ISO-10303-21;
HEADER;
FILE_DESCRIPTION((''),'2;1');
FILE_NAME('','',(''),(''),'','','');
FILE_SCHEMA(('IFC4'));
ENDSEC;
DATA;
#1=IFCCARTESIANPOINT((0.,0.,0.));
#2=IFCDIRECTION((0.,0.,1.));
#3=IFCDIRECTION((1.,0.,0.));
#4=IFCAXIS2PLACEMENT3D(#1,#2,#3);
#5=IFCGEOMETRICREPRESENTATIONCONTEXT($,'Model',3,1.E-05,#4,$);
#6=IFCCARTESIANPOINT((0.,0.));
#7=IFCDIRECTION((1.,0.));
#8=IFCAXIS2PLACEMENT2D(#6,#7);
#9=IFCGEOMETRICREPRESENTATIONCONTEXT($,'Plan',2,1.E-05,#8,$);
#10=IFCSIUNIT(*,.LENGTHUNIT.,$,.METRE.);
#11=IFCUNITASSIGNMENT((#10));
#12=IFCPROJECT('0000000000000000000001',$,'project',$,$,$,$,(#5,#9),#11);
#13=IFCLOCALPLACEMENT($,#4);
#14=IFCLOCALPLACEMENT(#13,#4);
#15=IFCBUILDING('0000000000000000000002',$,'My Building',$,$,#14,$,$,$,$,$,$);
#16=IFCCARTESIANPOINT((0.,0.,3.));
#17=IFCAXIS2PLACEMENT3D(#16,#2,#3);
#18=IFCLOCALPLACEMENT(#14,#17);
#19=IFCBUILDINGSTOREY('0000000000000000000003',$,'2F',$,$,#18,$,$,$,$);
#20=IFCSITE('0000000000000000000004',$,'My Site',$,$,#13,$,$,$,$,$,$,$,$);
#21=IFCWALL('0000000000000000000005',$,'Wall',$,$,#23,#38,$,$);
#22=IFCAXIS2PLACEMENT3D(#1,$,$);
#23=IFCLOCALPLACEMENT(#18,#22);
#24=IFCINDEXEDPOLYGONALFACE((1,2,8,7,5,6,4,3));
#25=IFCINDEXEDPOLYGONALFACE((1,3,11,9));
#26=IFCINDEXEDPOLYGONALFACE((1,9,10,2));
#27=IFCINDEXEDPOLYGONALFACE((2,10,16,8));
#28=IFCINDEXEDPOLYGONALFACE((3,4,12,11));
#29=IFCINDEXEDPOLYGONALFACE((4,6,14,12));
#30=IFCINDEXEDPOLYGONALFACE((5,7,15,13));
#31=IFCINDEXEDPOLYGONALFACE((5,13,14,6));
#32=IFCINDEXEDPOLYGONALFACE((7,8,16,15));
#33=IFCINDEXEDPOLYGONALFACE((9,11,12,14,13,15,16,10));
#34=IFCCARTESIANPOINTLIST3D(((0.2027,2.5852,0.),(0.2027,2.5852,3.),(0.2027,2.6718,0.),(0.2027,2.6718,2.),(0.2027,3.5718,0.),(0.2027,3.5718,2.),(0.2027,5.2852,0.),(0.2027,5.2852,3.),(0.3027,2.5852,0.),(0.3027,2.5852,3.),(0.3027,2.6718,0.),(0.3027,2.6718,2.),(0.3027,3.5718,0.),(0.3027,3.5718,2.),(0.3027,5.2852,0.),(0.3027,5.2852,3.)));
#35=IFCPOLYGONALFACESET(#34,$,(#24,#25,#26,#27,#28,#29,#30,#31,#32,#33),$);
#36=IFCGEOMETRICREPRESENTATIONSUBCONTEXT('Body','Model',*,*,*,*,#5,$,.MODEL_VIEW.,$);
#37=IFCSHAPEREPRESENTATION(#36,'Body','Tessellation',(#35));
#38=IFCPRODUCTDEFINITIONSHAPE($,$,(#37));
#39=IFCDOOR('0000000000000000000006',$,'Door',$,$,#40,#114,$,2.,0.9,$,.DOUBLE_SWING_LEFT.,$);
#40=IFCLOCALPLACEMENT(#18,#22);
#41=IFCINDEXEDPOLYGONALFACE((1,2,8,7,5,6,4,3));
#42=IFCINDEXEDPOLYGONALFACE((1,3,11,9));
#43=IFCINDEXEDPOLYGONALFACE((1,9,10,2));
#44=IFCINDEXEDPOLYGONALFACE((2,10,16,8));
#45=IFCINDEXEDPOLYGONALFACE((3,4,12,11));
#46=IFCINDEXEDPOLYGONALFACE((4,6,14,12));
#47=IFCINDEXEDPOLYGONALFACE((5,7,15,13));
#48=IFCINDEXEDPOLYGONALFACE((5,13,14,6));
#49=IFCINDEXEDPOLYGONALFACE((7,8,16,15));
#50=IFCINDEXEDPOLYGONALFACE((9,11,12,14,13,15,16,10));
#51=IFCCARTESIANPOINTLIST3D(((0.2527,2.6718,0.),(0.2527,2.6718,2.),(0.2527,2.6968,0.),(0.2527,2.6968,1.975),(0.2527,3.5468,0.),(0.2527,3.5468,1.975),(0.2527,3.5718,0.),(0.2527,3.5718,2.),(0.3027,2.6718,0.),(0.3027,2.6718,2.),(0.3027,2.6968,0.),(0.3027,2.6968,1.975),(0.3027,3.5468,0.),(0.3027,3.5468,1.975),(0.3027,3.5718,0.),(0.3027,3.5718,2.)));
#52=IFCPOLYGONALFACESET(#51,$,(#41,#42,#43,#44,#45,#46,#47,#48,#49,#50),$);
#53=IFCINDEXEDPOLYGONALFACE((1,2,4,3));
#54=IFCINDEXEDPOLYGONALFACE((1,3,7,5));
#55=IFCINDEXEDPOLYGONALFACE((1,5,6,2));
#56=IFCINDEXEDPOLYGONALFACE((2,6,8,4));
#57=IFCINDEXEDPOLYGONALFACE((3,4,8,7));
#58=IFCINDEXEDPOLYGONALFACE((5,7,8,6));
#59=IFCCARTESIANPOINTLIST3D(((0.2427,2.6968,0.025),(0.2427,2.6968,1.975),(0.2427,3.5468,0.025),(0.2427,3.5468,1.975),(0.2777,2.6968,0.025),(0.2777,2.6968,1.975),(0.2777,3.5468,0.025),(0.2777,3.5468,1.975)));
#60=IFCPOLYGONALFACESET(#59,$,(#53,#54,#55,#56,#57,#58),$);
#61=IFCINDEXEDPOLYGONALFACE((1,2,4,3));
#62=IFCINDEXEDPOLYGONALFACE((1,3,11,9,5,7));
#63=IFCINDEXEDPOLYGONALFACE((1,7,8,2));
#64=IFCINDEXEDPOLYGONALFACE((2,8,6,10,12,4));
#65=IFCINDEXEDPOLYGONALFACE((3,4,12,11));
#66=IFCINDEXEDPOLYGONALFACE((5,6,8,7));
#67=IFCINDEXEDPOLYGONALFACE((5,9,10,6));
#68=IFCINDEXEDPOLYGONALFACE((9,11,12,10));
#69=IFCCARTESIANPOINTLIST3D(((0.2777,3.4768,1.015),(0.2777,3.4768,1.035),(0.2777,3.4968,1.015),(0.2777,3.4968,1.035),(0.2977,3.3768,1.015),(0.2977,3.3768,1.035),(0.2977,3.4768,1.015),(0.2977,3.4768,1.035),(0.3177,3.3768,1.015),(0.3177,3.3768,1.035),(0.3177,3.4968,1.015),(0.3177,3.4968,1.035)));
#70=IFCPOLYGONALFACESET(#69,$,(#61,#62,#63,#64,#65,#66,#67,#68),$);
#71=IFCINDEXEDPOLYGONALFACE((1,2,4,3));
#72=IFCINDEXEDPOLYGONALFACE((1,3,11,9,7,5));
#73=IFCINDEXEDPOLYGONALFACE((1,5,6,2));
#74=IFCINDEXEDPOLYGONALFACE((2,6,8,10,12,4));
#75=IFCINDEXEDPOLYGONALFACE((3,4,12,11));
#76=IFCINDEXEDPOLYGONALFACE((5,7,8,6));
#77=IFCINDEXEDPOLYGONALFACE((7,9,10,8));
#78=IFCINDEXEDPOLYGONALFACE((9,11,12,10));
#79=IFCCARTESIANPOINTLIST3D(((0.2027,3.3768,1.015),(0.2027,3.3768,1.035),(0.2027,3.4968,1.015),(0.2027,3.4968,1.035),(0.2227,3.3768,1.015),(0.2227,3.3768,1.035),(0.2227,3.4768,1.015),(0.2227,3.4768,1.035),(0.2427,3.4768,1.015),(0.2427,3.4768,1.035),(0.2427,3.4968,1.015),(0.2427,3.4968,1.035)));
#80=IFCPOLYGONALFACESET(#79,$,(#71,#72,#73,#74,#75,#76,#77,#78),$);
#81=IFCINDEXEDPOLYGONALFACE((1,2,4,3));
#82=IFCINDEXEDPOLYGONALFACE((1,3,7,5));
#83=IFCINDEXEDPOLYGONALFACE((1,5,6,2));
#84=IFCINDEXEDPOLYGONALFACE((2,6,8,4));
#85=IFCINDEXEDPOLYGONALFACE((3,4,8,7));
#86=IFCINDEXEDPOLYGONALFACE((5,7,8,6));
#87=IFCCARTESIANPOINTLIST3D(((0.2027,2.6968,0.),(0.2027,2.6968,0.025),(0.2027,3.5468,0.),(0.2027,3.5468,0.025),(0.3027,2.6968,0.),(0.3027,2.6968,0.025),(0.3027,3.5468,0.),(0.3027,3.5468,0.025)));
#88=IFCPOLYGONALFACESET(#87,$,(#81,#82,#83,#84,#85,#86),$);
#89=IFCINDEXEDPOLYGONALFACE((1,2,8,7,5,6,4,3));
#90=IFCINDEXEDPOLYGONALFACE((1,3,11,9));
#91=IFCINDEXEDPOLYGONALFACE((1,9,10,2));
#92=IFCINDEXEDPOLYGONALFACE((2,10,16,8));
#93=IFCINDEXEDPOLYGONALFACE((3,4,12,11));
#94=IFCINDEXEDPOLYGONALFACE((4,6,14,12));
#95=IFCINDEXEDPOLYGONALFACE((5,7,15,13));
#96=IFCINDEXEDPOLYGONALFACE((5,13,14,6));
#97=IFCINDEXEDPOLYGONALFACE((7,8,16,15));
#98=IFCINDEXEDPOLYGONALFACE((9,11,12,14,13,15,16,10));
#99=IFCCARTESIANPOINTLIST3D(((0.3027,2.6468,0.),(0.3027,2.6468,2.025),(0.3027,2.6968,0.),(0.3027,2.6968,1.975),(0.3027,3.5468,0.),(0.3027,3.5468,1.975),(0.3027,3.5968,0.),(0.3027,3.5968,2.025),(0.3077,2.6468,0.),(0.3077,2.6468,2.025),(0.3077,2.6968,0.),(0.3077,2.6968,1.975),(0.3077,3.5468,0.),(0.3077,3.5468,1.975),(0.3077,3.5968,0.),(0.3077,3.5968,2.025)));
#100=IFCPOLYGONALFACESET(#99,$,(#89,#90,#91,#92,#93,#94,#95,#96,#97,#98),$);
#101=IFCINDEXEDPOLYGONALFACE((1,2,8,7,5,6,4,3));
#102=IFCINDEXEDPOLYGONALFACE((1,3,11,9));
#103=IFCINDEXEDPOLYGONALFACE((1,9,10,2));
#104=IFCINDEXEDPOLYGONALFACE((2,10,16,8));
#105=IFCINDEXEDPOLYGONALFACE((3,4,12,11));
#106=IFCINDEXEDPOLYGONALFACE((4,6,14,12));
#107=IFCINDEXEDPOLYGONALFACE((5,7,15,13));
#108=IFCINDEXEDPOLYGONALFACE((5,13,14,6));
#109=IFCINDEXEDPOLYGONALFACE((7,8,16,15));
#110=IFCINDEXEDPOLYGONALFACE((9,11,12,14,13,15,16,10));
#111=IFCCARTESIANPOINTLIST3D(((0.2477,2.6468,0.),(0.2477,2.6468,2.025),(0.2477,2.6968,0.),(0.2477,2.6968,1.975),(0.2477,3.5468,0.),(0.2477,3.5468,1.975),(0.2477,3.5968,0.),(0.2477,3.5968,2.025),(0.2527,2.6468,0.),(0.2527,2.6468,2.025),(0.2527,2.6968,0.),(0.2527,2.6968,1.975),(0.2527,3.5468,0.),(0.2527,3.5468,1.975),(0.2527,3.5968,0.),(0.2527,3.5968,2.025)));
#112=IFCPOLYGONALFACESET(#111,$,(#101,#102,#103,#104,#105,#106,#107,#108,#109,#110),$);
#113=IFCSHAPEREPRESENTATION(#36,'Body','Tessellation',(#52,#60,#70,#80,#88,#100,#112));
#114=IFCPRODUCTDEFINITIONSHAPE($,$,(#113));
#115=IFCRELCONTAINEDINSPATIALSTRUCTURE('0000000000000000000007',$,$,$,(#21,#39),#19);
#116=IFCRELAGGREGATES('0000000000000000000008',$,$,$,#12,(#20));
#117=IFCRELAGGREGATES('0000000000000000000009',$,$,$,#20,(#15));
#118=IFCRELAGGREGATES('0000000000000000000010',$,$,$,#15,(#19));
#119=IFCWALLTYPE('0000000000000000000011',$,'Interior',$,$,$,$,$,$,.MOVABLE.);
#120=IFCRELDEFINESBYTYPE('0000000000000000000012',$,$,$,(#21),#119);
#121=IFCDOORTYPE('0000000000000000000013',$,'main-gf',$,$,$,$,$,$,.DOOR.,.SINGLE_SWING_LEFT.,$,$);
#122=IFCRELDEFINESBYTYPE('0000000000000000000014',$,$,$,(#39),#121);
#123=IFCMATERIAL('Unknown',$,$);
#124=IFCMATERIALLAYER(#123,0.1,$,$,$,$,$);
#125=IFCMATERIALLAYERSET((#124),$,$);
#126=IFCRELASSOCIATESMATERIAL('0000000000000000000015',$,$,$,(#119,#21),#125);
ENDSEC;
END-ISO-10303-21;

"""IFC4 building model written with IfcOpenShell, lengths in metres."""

from ifc_helpers import new_model, entity, si_unit, frame, origin_with_axes, origin_2d_with_axis, place, context, subcontext, project, spatial, line, indexed_curve, outline, extrude, shape, source, transform, mapped, material, layer, layer_set, layer_usage, type_object, type_shapes, element, fill, save


model = new_model("IFC4")

# Units and contexts
model_context = context("Model", 3, precision=1e-05, world=origin_with_axes())
plan_context = context("Plan", 2, precision=1e-05, world=origin_2d_with_axis())
body_context_1 = subcontext(model_context, "Body", "Model", "MODEL_VIEW")
body_context_2 = subcontext(plan_context, "Body", "Plan", "PLAN_VIEW")
ifc_project = project(units=[si_unit("LENGTHUNIT", "METRE")], contexts=[model_context, plan_context])

# Site, building, storey
site_placement = place(None, origin_with_axes())
site = spatial("IfcSite", under=ifc_project, at=site_placement, Name="My Site")
building_placement = place(site_placement, origin_with_axes())
building = spatial("IfcBuilding", under=site, at=building_placement, Name="My Building")
storey_placement = place(building_placement, frame((0.0, 0.0, 3.0), z_axis=(0.0, 0.0, 1.0), x_axis=(1.0, 0.0, 0.0)))
storey = spatial("IfcBuildingStorey", under=building, at=storey_placement, Name="2F")

# Shared definitions
ifc_material = material(Name="Unknown")

# Shared definitions
ifc_layer_1 = layer(ifc_material, 0.1)
ifc_layer_set_1 = layer_set([ifc_layer_1])
wall_type = type_object("IfcWallType", Name="Interior", PredefinedType="MOVABLE", material=ifc_layer_set_1)

# Wall, opening, door
ifc_layer_usage_1 = layer_usage(ifc_layer_set_1, "AXIS2", "POSITIVE", 0.0)
wall_1_placement = place(storey_placement, frame((0.3027, 2.5852, 0.0), z_axis=(0.0, 0.0, 1.0), x_axis=(0.0, 1.0, 0.0)))
wall_1 = element("IfcWall", 1, at=wall_1_placement, inside=storey, type_object=wall_type, material=ifc_layer_usage_1, Name="Wall", context=body_context_1, shape_type="SweptSolid", body=[
    extrude(outline(indexed_curve([(0.0, 0.0), (0.0, 0.1), (2.7, 0.1), (2.7, 0.0)], segments=[line(1, 2, 3, 4, 1)])), origin_with_axes(), (0.0, 0.0, 1.0), 3.0),
])
shared_shape_1 = source(origin_with_axes(), body_context_1, "Body", "SweptSolid", [
    extrude(outline(indexed_curve([(0.0, 0.0), (0.9, 0.0), (0.9, 2.0), (0.0, 2.0)], segments=[line(1, 2, 3, 4, 1)])), frame((0.0, -0.6, 0.0), z_axis=(0.0, -1.0, 0.0), x_axis=(1.0, 0.0, 0.0)), (0.0, 0.0, -1.0), 1.2),
])
opening_1_placement = place(wall_1_placement, frame((0.0866, 0.0, 0.0), z_axis=(0.0, 0.0, 1.0), x_axis=(1.0, 0.0, 0.0)))
opening_1 = element("IfcOpeningElement", 2, at=opening_1_placement, cuts=wall_1, PredefinedType="OPENING", context=body_context_1, shape_type="MappedRepresentation", body=[
    mapped(shared_shape_1, transform((0.0, 0.0, 0.0), x_axis=(1.0, 0.0, 0.0), y_axis=(0.0, 1.0, 0.0), z_axis=(0.0, 0.0, 1.0), scale=1.0)),
])
door_type = type_object("IfcDoorType", Name="main-gf", OperationType="SINGLE_SWING_LEFT", PredefinedType="DOOR")
shared_shape_2 = source(origin_with_axes(), body_context_1, "Body", "SweptSolid", [
    extrude(outline(indexed_curve([(0.0, 0.0), (0.0, 2.0), (0.9, 2.0), (0.9, 0.0), (0.875, 0.0), (0.875, 1.975), (0.025, 1.975), (0.025, 0.0)], segments=[line(1, 2, 3, 4, 5, 6, 7, 8, 1)])), frame((0.0, 0.0, 0.0), z_axis=(0.0, -1.0, 0.0), x_axis=(1.0, 0.0, 0.0)), (0.0, 0.0, -1.0), 0.05),
    extrude(outline(indexed_curve([(0.0, 0.0), (0.85, 0.0), (0.85, 0.035), (0.0, 0.035)], segments=[line(1, 2, 3, 4, 1)])), frame((0.025, 0.025, 0.025), z_axis=(0.0, 0.0, 1.0), x_axis=(1.0, 0.0, 0.0)), (0.0, 0.0, 1.0), 1.95),
    extrude(outline(indexed_curve([(0.0, 0.0), (0.0, -0.04), (-0.12, -0.04), (-0.12, -0.02), (-0.02, -0.02), (-0.02, 0.0)], segments=[line(1, 2, 3, 4, 5, 6, 1)])), frame((0.825, 0.025, 1.015), z_axis=(0.0, 0.0, 1.0), x_axis=(1.0, 0.0, 0.0)), (0.0, 0.0, 1.0), 0.02),
    extrude(outline(indexed_curve([(0.0, 0.0), (0.0, 0.04), (-0.12, 0.04), (-0.12, 0.02), (-0.02, 0.02), (-0.02, 0.0)], segments=[line(1, 2, 3, 4, 5, 6, 1)])), frame((0.825, 0.06, 1.015), z_axis=(0.0, 0.0, 1.0), x_axis=(1.0, 0.0, 0.0)), (0.0, 0.0, 1.0), 0.02),
    extrude(outline(indexed_curve([(0.0, 0.0), (0.85, 0.0), (0.85, 0.1), (0.0, 0.1)], segments=[line(1, 2, 3, 4, 1)])), frame((0.025, 0.0, 0.0), z_axis=(0.0, 0.0, 1.0), x_axis=(1.0, 0.0, 0.0)), (0.0, 0.0, 1.0), 0.025),
    extrude(outline(indexed_curve([(0.0, 0.0), (0.0, 2.025), (0.95, 2.025), (0.95, 0.0), (0.9, 0.0), (0.9, 1.975), (0.05, 1.975), (0.05, 0.0)], segments=[line(1, 2, 3, 4, 5, 6, 7, 8, 1)])), frame((-0.025, -0.005, 0.0), z_axis=(0.0, -1.0, 0.0), x_axis=(1.0, 0.0, 0.0)), (0.0, 0.0, -1.0), 0.005),
    extrude(outline(indexed_curve([(0.0, 0.0), (0.0, 2.025), (0.95, 2.025), (0.95, 0.0), (0.9, 0.0), (0.9, 1.975), (0.05, 1.975), (0.05, 0.0)], segments=[line(1, 2, 3, 4, 5, 6, 7, 8, 1)])), frame((-0.025, 0.05, 0.0), z_axis=(0.0, -1.0, 0.0), x_axis=(1.0, 0.0, 0.0)), (0.0, 0.0, -1.0), 0.005),
])
shared_shape_3 = source(origin_with_axes(), body_context_2, "Body", "Curve2D", [
    entity("IfcIndexedPolyCurve", entity("IfcCartesianPointList2D", [[0.0, 0.0], [0.025, 0.0], [0.025, 0.05], [0.0, 0.05]]), [entity("IfcLineIndex", [1, 2, 3, 4, 1])]),
    entity("IfcIndexedPolyCurve", entity("IfcCartesianPointList2D", [[0.9, 0.0], [0.875, 0.0], [0.875, 0.05], [0.9, 0.05]]), [entity("IfcLineIndex", [1, 2, 3, 4, 1])]),
    entity("IfcIndexedPolyCurve", entity("IfcCartesianPointList2D", [[0.025, 0.05], [0.025, -0.8], [0.06, -0.8]])),
    entity("IfcTrimmedCurve", entity("IfcEllipse", entity("IfcAxis2Placement2D", entity("IfcCartesianPoint", [0.06, 0.05]), entity("IfcDirection", [1.0, 0.0])), 0.815, 0.85), [entity("IfcCartesianPoint", [0.06, -0.8])], [entity("IfcCartesianPoint", [0.06, 0.9])], True, "CARTESIAN"),
    entity("IfcIndexedPolyCurve", entity("IfcCartesianPointList2D", [[0.025, 0.05], [0.06, 0.05], [0.06, 0.9], [0.025, 0.9]]), [entity("IfcLineIndex", [1, 2, 3, 4, 1])]),
])
type_shapes(door_type, [shared_shape_2, shared_shape_3])
door_1_placement = place(opening_1_placement, frame((0.0, 0.0, 0.0), z_axis=(0.0, 0.0, 1.0), x_axis=(1.0, 0.0, 0.0)))
door_1 = element("IfcDoor", 3, at=door_1_placement, inside=storey, type_object=door_type, Name="Door", OperationType="DOUBLE_SWING_LEFT", OverallHeight=2.0, OverallWidth=0.9, shapes=[
    shape(body_context_1, "Body", "MappedRepresentation", [mapped(shared_shape_2, transform((0.0, 0.0, 0.0), x_axis=(1.0, 0.0, 0.0), y_axis=(0.0, 1.0, 0.0), z_axis=(0.0, 0.0, 1.0), scale=1.0))]),
    shape(body_context_2, "Body", "MappedRepresentation", [mapped(shared_shape_3, transform((0.0, 0.0, 0.0), x_axis=(1.0, 0.0, 0.0), y_axis=(0.0, 1.0, 0.0), z_axis=(0.0, 0.0, 1.0), scale=1.0))]),
])
fill(opening_1, door_1)

save(model, "model.ifc")
